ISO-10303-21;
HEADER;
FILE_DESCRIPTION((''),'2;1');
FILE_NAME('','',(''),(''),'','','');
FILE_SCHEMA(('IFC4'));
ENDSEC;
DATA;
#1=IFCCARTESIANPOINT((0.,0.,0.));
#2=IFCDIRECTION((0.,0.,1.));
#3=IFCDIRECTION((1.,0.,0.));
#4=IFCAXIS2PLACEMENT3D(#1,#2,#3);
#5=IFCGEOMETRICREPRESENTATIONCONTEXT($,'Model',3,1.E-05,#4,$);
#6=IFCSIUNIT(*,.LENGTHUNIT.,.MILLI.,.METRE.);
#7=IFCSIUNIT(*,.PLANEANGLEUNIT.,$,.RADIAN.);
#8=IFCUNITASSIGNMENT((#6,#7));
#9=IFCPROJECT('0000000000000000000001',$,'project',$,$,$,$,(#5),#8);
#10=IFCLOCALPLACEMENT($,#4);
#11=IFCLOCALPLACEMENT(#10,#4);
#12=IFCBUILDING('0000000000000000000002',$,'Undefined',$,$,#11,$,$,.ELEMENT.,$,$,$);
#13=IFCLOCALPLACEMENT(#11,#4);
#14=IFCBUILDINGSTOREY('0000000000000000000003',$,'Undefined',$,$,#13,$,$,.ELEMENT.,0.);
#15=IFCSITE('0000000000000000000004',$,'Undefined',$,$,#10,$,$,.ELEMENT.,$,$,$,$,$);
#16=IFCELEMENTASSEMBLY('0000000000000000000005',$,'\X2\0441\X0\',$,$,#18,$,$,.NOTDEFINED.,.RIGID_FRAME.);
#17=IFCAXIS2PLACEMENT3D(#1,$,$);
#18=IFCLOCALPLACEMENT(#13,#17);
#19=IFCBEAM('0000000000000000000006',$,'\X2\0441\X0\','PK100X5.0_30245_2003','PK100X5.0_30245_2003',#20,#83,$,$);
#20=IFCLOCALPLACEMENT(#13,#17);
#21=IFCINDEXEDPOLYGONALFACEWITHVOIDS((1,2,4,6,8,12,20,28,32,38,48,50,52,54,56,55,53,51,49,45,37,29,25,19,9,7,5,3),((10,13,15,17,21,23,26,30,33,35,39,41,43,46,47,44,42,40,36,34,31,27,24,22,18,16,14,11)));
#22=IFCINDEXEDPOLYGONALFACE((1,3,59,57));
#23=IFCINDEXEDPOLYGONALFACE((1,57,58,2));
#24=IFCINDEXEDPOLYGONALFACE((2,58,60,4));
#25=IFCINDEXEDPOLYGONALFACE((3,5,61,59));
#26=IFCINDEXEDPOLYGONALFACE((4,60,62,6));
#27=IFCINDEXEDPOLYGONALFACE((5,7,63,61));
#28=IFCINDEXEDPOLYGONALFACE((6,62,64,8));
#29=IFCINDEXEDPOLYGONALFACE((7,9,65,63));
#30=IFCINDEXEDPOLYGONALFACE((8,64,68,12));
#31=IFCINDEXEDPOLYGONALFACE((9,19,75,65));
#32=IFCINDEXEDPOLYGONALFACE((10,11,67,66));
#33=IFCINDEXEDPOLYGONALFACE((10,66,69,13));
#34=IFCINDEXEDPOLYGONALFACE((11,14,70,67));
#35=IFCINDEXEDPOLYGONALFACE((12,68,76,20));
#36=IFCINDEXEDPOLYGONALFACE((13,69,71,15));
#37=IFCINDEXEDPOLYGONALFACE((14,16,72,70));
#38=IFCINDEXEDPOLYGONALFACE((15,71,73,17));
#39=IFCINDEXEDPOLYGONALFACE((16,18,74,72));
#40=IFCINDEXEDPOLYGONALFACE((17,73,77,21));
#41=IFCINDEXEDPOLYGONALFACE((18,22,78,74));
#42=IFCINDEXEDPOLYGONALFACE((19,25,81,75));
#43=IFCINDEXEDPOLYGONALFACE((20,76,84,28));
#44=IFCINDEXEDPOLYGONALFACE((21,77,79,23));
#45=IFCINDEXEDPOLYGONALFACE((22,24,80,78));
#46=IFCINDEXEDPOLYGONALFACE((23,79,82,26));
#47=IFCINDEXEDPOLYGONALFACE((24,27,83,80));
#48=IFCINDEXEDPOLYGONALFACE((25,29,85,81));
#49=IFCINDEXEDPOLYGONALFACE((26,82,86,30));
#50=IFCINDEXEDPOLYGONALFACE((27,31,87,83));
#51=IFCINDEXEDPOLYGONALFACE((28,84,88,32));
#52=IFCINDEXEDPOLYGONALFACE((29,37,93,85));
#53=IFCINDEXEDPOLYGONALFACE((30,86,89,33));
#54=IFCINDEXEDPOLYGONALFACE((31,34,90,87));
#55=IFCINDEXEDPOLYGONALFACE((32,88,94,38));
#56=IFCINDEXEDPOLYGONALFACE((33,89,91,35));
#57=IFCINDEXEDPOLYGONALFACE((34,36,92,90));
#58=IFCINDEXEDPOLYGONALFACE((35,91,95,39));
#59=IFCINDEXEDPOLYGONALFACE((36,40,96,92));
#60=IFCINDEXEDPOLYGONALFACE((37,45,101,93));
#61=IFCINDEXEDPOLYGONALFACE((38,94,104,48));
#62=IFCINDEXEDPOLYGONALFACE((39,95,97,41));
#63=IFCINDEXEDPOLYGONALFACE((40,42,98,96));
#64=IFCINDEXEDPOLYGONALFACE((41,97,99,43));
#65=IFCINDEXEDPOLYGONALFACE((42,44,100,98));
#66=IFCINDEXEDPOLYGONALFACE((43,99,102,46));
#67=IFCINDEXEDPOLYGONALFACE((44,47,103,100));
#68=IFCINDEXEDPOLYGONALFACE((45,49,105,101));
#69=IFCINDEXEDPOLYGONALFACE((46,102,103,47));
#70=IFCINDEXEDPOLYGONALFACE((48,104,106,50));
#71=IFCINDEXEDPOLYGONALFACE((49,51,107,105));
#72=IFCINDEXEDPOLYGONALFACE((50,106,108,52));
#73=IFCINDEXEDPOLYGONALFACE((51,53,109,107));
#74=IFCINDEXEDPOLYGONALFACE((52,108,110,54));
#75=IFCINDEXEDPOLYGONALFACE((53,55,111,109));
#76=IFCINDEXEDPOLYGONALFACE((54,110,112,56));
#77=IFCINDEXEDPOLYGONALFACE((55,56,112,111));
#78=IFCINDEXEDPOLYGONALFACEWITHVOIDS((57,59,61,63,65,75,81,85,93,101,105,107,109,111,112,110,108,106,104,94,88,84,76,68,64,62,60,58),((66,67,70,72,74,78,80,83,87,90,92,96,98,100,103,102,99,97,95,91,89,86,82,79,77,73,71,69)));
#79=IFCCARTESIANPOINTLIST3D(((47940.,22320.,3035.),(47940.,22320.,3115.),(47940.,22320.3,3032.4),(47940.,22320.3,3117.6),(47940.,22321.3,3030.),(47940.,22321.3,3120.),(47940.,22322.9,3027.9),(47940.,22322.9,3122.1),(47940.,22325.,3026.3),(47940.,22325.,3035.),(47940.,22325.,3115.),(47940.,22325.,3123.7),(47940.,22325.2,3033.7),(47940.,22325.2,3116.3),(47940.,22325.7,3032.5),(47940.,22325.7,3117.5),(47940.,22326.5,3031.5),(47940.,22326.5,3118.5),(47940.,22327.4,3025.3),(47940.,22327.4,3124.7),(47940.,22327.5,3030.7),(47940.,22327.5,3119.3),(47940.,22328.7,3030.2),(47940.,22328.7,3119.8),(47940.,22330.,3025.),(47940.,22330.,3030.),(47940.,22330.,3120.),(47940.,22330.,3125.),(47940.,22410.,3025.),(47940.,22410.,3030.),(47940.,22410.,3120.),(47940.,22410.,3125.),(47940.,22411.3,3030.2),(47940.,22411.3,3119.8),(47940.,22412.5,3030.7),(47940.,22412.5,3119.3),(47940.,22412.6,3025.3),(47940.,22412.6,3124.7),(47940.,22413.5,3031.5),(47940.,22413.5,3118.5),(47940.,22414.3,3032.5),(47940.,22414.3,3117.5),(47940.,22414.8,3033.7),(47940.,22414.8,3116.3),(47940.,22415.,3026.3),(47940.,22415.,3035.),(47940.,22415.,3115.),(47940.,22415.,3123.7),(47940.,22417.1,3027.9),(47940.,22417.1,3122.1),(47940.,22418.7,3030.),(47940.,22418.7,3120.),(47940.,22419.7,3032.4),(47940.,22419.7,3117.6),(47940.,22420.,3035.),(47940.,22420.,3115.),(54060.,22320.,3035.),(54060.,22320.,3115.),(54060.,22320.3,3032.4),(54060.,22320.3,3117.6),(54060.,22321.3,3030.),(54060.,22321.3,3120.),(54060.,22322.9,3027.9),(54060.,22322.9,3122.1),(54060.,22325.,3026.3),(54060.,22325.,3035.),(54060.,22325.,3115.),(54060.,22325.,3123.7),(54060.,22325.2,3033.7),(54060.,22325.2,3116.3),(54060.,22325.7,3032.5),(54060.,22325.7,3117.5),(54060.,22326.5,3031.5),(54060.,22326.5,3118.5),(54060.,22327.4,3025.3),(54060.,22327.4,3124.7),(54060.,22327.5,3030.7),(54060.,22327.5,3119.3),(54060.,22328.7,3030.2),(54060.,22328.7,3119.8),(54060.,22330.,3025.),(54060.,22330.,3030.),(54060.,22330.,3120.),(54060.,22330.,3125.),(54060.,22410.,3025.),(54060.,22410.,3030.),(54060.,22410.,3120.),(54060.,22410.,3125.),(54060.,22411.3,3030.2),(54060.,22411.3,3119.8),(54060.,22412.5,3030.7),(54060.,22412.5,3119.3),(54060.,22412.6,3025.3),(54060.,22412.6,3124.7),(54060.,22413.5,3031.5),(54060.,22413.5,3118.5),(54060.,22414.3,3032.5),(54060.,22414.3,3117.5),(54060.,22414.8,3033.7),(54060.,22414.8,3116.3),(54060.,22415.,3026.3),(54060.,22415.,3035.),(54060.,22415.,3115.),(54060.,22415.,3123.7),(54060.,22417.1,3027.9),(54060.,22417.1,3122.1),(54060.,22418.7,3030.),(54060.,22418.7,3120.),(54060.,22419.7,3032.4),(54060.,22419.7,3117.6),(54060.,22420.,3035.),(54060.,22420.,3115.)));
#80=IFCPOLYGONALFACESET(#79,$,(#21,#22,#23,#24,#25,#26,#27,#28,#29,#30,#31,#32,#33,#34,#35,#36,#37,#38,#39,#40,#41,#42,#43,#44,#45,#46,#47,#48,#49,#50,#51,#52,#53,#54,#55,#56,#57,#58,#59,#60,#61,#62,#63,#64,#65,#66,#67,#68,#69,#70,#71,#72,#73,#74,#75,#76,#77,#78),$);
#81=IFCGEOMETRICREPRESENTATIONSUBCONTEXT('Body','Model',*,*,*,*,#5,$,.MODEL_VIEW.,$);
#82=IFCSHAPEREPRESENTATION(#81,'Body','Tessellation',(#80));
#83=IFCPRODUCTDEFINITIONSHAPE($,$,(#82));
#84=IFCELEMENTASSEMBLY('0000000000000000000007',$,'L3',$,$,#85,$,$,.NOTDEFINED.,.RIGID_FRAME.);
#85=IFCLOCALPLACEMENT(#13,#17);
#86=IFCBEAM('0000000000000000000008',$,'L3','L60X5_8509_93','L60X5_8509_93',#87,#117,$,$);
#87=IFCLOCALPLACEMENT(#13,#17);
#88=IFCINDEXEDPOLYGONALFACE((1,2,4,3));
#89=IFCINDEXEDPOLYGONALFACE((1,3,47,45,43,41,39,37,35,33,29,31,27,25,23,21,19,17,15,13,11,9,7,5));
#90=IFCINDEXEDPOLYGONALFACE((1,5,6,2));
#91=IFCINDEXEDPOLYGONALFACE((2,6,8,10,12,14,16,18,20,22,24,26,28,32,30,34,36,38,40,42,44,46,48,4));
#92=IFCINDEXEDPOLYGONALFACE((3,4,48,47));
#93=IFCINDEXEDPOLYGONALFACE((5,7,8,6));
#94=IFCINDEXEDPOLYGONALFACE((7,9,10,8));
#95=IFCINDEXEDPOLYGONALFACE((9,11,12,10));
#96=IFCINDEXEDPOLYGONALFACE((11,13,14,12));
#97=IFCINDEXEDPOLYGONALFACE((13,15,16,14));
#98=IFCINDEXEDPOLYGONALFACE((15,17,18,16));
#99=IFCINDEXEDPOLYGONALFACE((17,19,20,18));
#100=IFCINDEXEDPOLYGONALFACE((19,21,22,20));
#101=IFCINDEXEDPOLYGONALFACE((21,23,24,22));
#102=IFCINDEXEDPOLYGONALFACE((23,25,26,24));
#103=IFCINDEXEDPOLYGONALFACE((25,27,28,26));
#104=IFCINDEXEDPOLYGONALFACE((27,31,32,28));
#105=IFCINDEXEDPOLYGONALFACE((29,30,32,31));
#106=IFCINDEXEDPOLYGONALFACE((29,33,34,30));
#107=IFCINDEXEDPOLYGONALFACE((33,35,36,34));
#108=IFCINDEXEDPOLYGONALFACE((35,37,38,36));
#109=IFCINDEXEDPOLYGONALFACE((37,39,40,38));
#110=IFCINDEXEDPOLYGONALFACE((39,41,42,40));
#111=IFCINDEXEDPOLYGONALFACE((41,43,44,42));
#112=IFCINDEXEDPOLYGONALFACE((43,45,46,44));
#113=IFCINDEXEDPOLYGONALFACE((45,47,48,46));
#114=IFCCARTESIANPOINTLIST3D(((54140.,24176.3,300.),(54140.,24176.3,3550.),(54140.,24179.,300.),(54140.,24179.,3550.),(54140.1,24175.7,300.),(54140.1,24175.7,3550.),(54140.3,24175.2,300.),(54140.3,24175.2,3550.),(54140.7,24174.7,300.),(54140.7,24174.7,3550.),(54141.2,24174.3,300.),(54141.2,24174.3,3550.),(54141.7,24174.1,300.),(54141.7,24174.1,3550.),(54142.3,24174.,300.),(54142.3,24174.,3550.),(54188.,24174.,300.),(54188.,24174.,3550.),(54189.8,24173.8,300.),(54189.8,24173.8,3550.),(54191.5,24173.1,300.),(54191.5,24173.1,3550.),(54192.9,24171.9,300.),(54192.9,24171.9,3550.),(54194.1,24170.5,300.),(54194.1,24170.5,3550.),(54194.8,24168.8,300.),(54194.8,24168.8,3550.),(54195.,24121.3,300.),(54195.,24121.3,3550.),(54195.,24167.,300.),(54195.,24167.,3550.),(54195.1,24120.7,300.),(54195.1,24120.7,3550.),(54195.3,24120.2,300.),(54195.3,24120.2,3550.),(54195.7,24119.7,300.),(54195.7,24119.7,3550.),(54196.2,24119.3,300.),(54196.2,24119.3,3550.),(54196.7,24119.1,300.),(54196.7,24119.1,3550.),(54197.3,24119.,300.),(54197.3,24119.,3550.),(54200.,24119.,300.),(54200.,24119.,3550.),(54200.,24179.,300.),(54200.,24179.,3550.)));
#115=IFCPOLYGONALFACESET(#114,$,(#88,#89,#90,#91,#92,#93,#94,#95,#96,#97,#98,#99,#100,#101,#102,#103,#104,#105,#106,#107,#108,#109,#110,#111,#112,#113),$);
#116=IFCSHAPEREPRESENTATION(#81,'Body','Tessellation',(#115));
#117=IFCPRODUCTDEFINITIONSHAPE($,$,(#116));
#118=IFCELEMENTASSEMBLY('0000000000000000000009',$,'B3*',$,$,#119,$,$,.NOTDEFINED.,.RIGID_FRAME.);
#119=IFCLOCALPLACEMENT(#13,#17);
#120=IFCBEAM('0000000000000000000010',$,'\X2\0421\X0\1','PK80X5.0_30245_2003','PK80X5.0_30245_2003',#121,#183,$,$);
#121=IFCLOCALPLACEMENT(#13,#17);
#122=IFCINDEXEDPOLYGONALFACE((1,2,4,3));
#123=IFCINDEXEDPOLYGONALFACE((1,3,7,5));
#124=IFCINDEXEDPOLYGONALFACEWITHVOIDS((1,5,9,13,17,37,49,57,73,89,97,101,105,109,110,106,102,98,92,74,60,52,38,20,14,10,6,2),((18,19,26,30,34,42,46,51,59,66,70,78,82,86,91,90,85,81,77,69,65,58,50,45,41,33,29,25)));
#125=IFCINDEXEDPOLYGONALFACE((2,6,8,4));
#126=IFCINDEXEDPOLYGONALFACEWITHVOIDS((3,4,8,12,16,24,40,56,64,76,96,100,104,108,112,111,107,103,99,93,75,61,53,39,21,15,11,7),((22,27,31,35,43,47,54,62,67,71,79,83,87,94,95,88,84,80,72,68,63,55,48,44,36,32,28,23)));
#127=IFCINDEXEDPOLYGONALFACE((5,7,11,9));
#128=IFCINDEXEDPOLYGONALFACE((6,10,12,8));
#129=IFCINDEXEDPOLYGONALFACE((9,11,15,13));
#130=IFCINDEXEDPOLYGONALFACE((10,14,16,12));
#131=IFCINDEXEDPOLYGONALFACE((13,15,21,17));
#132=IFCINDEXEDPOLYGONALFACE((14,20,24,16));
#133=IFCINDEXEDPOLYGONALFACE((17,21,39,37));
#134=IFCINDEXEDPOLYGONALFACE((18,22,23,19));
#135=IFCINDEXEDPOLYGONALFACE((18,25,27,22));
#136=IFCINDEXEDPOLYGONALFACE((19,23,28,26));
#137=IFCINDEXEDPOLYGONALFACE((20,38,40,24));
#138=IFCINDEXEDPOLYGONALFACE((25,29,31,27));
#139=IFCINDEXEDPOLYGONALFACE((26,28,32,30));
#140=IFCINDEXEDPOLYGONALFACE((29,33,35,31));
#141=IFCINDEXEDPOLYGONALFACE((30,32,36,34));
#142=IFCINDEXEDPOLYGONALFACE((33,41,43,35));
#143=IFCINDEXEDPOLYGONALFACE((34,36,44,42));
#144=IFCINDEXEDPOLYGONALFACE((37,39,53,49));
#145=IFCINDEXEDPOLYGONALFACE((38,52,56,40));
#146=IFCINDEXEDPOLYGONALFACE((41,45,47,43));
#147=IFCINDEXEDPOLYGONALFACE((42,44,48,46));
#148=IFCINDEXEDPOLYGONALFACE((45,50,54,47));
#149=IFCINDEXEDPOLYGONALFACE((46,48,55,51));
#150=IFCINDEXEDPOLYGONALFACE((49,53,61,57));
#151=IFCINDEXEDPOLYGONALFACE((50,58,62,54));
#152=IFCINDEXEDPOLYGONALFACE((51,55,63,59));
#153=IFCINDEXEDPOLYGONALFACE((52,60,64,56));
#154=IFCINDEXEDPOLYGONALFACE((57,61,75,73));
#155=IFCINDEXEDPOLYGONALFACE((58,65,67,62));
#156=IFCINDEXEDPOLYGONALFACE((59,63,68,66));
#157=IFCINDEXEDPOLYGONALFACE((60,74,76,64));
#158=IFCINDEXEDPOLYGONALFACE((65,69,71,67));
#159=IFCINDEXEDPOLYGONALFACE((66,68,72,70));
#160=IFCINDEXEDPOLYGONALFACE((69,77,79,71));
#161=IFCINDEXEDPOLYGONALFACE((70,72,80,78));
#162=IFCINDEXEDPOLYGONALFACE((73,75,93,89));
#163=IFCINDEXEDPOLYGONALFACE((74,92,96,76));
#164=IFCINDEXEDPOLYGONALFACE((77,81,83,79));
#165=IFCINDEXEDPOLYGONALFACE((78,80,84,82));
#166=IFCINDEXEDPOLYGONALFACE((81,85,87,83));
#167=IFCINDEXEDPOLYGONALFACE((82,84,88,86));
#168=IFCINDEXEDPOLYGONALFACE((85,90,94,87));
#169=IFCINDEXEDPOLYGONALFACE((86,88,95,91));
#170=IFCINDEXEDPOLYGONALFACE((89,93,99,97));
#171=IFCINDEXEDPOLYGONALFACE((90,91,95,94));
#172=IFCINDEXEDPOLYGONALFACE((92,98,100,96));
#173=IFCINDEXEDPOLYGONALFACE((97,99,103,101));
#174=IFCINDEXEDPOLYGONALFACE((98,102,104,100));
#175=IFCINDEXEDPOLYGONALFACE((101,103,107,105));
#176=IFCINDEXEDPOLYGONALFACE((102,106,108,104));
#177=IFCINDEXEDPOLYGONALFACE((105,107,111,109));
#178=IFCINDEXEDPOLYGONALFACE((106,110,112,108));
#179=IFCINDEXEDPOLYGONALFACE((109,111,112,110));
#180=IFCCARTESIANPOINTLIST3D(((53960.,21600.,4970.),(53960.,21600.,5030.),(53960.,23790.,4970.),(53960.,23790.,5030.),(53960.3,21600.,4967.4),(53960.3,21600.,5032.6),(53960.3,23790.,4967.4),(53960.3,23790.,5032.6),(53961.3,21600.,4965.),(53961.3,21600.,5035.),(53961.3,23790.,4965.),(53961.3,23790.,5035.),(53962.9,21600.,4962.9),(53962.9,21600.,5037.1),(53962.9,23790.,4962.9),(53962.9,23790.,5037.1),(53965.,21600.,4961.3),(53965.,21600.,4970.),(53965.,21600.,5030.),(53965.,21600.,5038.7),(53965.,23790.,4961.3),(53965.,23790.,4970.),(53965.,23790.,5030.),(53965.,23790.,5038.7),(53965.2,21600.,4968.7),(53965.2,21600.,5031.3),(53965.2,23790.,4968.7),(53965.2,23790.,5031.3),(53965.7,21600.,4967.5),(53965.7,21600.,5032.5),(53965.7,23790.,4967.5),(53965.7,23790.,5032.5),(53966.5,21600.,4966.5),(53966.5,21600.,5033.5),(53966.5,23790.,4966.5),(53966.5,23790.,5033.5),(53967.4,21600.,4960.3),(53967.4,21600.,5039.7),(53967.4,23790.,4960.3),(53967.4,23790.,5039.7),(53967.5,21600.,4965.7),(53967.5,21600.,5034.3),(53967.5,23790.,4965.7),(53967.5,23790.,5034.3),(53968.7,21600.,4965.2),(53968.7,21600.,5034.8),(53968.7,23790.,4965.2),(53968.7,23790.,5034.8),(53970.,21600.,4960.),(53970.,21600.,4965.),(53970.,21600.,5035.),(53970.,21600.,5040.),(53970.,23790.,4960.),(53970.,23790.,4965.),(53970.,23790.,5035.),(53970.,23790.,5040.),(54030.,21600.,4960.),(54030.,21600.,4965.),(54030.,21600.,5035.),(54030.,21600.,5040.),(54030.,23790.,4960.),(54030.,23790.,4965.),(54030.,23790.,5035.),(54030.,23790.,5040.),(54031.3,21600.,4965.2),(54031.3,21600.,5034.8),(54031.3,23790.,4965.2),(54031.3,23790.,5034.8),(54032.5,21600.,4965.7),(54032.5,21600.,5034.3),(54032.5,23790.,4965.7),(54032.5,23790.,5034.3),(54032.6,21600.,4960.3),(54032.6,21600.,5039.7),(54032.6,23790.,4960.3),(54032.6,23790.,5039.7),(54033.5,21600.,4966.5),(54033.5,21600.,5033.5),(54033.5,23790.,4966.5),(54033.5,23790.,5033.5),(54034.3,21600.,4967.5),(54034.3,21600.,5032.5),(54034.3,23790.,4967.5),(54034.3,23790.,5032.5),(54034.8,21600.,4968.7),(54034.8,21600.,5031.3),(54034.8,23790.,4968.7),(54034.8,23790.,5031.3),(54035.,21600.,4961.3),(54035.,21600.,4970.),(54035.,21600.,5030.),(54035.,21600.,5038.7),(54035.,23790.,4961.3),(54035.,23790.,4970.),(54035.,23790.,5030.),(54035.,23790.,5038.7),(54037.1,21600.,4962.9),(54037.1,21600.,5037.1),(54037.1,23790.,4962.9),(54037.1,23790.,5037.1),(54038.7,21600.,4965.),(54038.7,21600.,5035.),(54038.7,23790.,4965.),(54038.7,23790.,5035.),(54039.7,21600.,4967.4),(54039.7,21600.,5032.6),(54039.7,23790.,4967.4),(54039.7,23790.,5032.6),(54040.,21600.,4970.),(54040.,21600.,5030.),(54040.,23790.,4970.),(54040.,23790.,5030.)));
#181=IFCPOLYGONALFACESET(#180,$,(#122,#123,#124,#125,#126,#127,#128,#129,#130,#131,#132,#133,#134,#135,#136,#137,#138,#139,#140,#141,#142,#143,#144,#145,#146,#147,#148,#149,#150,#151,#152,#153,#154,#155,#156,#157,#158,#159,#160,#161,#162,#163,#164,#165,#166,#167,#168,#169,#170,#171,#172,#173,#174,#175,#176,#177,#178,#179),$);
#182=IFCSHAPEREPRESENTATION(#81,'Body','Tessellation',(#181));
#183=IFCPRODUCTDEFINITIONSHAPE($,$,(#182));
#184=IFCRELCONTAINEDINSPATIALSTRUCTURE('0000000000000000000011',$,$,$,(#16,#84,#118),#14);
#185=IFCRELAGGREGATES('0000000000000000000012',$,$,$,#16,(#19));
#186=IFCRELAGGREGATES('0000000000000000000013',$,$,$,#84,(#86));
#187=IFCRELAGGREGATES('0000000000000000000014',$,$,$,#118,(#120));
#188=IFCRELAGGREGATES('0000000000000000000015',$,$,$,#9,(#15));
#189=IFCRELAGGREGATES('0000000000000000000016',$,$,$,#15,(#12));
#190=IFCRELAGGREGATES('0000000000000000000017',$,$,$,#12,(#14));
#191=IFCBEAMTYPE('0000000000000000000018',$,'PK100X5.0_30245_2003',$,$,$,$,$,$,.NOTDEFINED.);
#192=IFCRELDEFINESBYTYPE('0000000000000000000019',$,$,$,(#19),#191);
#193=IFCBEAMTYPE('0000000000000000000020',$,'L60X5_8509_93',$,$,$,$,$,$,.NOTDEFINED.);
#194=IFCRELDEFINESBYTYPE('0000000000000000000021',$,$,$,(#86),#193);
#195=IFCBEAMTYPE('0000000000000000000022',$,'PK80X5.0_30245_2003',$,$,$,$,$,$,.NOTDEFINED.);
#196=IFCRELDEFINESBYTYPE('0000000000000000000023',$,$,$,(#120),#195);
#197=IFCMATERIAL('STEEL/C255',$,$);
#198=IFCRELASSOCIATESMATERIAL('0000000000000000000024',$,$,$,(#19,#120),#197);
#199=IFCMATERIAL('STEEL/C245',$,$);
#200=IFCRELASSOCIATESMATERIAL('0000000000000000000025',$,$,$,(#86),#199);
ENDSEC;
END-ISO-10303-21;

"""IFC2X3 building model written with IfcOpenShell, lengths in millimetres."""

from ifc_helpers import new_model, si_unit, frame, origin_with_axes, origin_2d_with_axis, place, context, subcontext, project, spatial, hollow_rectangle, l_section, extrude, material, type_object, element, aggregate, save


model = new_model("IFC2X3")

# Units and contexts
model_context = context("Model", 3, precision=1e-05, world=origin_with_axes())
body_context = subcontext(model_context, "Body", "Model", "MODEL_VIEW")
ifc_project = project(units=[si_unit("LENGTHUNIT", "METRE", prefix="MILLI"), si_unit("PLANEANGLEUNIT", "RADIAN")], contexts=[model_context])

# Site, building, storey
site_placement = place(None, origin_with_axes())
site = spatial("IfcSite", under=ifc_project, at=site_placement, Name="Undefined", CompositionType="ELEMENT")
building_placement = place(site_placement, origin_with_axes())
building = spatial("IfcBuilding", under=site, at=building_placement, Name="Undefined", CompositionType="ELEMENT")
storey_placement = place(building_placement, origin_with_axes())
storey = spatial("IfcBuildingStorey", under=building, at=storey_placement, Name="Undefined", CompositionType="ELEMENT", Elevation=0.0)

# Shared definitions
ifc_material_1 = material(Name="STEEL/C255")

# Element assemblies, beams
assembly_1_placement = place(storey_placement, origin_with_axes())
assembly_1 = element("IfcElementAssembly", 1, at=assembly_1_placement, inside=storey, Name="с", AssemblyPlace="NOTDEFINED", PredefinedType="RIGID_FRAME")
beam_type_1 = type_object("IfcBeamType", Name="PK100X5.0_30245_2003", PredefinedType="NOTDEFINED")
beam_1_placement = place(assembly_1_placement, frame((54060.0, 22370.0, 3075.0), z_axis=(0.0, -1.0, 0.0), x_axis=(-1.0, 0.0, 0.0)))
beam_1 = element("IfcBeam", 2, at=beam_1_placement, type_object=beam_type_1, material=ifc_material_1, Name="с", Description="PK100X5.0_30245_2003", ObjectType="PK100X5.0_30245_2003", context=body_context, shape_type="SweptSolid", body=[
    extrude(hollow_rectangle(XDim=100.0, YDim=100.0, WallThickness=5.0, InnerFilletRadius=5.0, OuterFilletRadius=10.0, at=origin_2d_with_axis()), frame((6120.0, 0.0, 0.0), z_axis=(-1.0, 0.0, 0.0), x_axis=(0.0, -1.0, 0.0)), (0.0, 0.0, 1.0), 6120.0),
])
aggregate(assembly_1, [beam_1])
assembly_2_placement = place(storey_placement, origin_with_axes())
assembly_2 = element("IfcElementAssembly", 3, at=assembly_2_placement, inside=storey, Name="L3", AssemblyPlace="NOTDEFINED", PredefinedType="RIGID_FRAME")
ifc_material_2 = material(Name="STEEL/C245")
beam_type_2 = type_object("IfcBeamType", Name="L60X5_8509_93", PredefinedType="NOTDEFINED")
beam_2_placement = place(assembly_2_placement, frame((54170.0, 24149.0, 3550.0), z_axis=(0.0, -1.0, 0.0), x_axis=(0.0, 0.0, -1.0)))
beam_2 = element("IfcBeam", 4, at=beam_2_placement, type_object=beam_type_2, material=ifc_material_2, Name="L3", Description="L60X5_8509_93", ObjectType="L60X5_8509_93", context=body_context, shape_type="SweptSolid", body=[
    extrude(l_section(Depth=60.0, Width=60.0, Thickness=5.0, FilletRadius=7.0, EdgeRadius=2.3, at=origin_2d_with_axis()), frame((3250.0, 0.0, 0.0), z_axis=(-1.0, 0.0, 0.0), x_axis=(0.0, -1.0, 0.0)), (0.0, 0.0, 1.0), 3250.0),
])
aggregate(assembly_2, [beam_2])
assembly_3_placement = place(storey_placement, origin_with_axes())
assembly_3 = element("IfcElementAssembly", 5, at=assembly_3_placement, inside=storey, Name="B3*", AssemblyPlace="NOTDEFINED", PredefinedType="RIGID_FRAME")
beam_type_3 = type_object("IfcBeamType", Name="PK80X5.0_30245_2003", PredefinedType="NOTDEFINED")
beam_3_placement = place(assembly_3_placement, frame((54000.0, 23790.0, 5000.0), z_axis=(1.0, 0.0, 0.0), x_axis=(0.0, -1.0, 0.0)))
beam_3 = element("IfcBeam", 6, at=beam_3_placement, type_object=beam_type_3, material=ifc_material_1, Name="С1", Description="PK80X5.0_30245_2003", ObjectType="PK80X5.0_30245_2003", context=body_context, shape_type="SweptSolid", body=[
    extrude(hollow_rectangle(XDim=80.0, YDim=80.0, WallThickness=5.0, InnerFilletRadius=5.0, OuterFilletRadius=10.0, at=origin_2d_with_axis()), frame((2190.0, 0.0, 0.0), z_axis=(-1.0, 0.0, 0.0), x_axis=(0.0, -1.0, 0.0)), (0.0, 0.0, 1.0), 2190.0),
])
aggregate(assembly_3, [beam_3])

save(model, "model.ifc")
